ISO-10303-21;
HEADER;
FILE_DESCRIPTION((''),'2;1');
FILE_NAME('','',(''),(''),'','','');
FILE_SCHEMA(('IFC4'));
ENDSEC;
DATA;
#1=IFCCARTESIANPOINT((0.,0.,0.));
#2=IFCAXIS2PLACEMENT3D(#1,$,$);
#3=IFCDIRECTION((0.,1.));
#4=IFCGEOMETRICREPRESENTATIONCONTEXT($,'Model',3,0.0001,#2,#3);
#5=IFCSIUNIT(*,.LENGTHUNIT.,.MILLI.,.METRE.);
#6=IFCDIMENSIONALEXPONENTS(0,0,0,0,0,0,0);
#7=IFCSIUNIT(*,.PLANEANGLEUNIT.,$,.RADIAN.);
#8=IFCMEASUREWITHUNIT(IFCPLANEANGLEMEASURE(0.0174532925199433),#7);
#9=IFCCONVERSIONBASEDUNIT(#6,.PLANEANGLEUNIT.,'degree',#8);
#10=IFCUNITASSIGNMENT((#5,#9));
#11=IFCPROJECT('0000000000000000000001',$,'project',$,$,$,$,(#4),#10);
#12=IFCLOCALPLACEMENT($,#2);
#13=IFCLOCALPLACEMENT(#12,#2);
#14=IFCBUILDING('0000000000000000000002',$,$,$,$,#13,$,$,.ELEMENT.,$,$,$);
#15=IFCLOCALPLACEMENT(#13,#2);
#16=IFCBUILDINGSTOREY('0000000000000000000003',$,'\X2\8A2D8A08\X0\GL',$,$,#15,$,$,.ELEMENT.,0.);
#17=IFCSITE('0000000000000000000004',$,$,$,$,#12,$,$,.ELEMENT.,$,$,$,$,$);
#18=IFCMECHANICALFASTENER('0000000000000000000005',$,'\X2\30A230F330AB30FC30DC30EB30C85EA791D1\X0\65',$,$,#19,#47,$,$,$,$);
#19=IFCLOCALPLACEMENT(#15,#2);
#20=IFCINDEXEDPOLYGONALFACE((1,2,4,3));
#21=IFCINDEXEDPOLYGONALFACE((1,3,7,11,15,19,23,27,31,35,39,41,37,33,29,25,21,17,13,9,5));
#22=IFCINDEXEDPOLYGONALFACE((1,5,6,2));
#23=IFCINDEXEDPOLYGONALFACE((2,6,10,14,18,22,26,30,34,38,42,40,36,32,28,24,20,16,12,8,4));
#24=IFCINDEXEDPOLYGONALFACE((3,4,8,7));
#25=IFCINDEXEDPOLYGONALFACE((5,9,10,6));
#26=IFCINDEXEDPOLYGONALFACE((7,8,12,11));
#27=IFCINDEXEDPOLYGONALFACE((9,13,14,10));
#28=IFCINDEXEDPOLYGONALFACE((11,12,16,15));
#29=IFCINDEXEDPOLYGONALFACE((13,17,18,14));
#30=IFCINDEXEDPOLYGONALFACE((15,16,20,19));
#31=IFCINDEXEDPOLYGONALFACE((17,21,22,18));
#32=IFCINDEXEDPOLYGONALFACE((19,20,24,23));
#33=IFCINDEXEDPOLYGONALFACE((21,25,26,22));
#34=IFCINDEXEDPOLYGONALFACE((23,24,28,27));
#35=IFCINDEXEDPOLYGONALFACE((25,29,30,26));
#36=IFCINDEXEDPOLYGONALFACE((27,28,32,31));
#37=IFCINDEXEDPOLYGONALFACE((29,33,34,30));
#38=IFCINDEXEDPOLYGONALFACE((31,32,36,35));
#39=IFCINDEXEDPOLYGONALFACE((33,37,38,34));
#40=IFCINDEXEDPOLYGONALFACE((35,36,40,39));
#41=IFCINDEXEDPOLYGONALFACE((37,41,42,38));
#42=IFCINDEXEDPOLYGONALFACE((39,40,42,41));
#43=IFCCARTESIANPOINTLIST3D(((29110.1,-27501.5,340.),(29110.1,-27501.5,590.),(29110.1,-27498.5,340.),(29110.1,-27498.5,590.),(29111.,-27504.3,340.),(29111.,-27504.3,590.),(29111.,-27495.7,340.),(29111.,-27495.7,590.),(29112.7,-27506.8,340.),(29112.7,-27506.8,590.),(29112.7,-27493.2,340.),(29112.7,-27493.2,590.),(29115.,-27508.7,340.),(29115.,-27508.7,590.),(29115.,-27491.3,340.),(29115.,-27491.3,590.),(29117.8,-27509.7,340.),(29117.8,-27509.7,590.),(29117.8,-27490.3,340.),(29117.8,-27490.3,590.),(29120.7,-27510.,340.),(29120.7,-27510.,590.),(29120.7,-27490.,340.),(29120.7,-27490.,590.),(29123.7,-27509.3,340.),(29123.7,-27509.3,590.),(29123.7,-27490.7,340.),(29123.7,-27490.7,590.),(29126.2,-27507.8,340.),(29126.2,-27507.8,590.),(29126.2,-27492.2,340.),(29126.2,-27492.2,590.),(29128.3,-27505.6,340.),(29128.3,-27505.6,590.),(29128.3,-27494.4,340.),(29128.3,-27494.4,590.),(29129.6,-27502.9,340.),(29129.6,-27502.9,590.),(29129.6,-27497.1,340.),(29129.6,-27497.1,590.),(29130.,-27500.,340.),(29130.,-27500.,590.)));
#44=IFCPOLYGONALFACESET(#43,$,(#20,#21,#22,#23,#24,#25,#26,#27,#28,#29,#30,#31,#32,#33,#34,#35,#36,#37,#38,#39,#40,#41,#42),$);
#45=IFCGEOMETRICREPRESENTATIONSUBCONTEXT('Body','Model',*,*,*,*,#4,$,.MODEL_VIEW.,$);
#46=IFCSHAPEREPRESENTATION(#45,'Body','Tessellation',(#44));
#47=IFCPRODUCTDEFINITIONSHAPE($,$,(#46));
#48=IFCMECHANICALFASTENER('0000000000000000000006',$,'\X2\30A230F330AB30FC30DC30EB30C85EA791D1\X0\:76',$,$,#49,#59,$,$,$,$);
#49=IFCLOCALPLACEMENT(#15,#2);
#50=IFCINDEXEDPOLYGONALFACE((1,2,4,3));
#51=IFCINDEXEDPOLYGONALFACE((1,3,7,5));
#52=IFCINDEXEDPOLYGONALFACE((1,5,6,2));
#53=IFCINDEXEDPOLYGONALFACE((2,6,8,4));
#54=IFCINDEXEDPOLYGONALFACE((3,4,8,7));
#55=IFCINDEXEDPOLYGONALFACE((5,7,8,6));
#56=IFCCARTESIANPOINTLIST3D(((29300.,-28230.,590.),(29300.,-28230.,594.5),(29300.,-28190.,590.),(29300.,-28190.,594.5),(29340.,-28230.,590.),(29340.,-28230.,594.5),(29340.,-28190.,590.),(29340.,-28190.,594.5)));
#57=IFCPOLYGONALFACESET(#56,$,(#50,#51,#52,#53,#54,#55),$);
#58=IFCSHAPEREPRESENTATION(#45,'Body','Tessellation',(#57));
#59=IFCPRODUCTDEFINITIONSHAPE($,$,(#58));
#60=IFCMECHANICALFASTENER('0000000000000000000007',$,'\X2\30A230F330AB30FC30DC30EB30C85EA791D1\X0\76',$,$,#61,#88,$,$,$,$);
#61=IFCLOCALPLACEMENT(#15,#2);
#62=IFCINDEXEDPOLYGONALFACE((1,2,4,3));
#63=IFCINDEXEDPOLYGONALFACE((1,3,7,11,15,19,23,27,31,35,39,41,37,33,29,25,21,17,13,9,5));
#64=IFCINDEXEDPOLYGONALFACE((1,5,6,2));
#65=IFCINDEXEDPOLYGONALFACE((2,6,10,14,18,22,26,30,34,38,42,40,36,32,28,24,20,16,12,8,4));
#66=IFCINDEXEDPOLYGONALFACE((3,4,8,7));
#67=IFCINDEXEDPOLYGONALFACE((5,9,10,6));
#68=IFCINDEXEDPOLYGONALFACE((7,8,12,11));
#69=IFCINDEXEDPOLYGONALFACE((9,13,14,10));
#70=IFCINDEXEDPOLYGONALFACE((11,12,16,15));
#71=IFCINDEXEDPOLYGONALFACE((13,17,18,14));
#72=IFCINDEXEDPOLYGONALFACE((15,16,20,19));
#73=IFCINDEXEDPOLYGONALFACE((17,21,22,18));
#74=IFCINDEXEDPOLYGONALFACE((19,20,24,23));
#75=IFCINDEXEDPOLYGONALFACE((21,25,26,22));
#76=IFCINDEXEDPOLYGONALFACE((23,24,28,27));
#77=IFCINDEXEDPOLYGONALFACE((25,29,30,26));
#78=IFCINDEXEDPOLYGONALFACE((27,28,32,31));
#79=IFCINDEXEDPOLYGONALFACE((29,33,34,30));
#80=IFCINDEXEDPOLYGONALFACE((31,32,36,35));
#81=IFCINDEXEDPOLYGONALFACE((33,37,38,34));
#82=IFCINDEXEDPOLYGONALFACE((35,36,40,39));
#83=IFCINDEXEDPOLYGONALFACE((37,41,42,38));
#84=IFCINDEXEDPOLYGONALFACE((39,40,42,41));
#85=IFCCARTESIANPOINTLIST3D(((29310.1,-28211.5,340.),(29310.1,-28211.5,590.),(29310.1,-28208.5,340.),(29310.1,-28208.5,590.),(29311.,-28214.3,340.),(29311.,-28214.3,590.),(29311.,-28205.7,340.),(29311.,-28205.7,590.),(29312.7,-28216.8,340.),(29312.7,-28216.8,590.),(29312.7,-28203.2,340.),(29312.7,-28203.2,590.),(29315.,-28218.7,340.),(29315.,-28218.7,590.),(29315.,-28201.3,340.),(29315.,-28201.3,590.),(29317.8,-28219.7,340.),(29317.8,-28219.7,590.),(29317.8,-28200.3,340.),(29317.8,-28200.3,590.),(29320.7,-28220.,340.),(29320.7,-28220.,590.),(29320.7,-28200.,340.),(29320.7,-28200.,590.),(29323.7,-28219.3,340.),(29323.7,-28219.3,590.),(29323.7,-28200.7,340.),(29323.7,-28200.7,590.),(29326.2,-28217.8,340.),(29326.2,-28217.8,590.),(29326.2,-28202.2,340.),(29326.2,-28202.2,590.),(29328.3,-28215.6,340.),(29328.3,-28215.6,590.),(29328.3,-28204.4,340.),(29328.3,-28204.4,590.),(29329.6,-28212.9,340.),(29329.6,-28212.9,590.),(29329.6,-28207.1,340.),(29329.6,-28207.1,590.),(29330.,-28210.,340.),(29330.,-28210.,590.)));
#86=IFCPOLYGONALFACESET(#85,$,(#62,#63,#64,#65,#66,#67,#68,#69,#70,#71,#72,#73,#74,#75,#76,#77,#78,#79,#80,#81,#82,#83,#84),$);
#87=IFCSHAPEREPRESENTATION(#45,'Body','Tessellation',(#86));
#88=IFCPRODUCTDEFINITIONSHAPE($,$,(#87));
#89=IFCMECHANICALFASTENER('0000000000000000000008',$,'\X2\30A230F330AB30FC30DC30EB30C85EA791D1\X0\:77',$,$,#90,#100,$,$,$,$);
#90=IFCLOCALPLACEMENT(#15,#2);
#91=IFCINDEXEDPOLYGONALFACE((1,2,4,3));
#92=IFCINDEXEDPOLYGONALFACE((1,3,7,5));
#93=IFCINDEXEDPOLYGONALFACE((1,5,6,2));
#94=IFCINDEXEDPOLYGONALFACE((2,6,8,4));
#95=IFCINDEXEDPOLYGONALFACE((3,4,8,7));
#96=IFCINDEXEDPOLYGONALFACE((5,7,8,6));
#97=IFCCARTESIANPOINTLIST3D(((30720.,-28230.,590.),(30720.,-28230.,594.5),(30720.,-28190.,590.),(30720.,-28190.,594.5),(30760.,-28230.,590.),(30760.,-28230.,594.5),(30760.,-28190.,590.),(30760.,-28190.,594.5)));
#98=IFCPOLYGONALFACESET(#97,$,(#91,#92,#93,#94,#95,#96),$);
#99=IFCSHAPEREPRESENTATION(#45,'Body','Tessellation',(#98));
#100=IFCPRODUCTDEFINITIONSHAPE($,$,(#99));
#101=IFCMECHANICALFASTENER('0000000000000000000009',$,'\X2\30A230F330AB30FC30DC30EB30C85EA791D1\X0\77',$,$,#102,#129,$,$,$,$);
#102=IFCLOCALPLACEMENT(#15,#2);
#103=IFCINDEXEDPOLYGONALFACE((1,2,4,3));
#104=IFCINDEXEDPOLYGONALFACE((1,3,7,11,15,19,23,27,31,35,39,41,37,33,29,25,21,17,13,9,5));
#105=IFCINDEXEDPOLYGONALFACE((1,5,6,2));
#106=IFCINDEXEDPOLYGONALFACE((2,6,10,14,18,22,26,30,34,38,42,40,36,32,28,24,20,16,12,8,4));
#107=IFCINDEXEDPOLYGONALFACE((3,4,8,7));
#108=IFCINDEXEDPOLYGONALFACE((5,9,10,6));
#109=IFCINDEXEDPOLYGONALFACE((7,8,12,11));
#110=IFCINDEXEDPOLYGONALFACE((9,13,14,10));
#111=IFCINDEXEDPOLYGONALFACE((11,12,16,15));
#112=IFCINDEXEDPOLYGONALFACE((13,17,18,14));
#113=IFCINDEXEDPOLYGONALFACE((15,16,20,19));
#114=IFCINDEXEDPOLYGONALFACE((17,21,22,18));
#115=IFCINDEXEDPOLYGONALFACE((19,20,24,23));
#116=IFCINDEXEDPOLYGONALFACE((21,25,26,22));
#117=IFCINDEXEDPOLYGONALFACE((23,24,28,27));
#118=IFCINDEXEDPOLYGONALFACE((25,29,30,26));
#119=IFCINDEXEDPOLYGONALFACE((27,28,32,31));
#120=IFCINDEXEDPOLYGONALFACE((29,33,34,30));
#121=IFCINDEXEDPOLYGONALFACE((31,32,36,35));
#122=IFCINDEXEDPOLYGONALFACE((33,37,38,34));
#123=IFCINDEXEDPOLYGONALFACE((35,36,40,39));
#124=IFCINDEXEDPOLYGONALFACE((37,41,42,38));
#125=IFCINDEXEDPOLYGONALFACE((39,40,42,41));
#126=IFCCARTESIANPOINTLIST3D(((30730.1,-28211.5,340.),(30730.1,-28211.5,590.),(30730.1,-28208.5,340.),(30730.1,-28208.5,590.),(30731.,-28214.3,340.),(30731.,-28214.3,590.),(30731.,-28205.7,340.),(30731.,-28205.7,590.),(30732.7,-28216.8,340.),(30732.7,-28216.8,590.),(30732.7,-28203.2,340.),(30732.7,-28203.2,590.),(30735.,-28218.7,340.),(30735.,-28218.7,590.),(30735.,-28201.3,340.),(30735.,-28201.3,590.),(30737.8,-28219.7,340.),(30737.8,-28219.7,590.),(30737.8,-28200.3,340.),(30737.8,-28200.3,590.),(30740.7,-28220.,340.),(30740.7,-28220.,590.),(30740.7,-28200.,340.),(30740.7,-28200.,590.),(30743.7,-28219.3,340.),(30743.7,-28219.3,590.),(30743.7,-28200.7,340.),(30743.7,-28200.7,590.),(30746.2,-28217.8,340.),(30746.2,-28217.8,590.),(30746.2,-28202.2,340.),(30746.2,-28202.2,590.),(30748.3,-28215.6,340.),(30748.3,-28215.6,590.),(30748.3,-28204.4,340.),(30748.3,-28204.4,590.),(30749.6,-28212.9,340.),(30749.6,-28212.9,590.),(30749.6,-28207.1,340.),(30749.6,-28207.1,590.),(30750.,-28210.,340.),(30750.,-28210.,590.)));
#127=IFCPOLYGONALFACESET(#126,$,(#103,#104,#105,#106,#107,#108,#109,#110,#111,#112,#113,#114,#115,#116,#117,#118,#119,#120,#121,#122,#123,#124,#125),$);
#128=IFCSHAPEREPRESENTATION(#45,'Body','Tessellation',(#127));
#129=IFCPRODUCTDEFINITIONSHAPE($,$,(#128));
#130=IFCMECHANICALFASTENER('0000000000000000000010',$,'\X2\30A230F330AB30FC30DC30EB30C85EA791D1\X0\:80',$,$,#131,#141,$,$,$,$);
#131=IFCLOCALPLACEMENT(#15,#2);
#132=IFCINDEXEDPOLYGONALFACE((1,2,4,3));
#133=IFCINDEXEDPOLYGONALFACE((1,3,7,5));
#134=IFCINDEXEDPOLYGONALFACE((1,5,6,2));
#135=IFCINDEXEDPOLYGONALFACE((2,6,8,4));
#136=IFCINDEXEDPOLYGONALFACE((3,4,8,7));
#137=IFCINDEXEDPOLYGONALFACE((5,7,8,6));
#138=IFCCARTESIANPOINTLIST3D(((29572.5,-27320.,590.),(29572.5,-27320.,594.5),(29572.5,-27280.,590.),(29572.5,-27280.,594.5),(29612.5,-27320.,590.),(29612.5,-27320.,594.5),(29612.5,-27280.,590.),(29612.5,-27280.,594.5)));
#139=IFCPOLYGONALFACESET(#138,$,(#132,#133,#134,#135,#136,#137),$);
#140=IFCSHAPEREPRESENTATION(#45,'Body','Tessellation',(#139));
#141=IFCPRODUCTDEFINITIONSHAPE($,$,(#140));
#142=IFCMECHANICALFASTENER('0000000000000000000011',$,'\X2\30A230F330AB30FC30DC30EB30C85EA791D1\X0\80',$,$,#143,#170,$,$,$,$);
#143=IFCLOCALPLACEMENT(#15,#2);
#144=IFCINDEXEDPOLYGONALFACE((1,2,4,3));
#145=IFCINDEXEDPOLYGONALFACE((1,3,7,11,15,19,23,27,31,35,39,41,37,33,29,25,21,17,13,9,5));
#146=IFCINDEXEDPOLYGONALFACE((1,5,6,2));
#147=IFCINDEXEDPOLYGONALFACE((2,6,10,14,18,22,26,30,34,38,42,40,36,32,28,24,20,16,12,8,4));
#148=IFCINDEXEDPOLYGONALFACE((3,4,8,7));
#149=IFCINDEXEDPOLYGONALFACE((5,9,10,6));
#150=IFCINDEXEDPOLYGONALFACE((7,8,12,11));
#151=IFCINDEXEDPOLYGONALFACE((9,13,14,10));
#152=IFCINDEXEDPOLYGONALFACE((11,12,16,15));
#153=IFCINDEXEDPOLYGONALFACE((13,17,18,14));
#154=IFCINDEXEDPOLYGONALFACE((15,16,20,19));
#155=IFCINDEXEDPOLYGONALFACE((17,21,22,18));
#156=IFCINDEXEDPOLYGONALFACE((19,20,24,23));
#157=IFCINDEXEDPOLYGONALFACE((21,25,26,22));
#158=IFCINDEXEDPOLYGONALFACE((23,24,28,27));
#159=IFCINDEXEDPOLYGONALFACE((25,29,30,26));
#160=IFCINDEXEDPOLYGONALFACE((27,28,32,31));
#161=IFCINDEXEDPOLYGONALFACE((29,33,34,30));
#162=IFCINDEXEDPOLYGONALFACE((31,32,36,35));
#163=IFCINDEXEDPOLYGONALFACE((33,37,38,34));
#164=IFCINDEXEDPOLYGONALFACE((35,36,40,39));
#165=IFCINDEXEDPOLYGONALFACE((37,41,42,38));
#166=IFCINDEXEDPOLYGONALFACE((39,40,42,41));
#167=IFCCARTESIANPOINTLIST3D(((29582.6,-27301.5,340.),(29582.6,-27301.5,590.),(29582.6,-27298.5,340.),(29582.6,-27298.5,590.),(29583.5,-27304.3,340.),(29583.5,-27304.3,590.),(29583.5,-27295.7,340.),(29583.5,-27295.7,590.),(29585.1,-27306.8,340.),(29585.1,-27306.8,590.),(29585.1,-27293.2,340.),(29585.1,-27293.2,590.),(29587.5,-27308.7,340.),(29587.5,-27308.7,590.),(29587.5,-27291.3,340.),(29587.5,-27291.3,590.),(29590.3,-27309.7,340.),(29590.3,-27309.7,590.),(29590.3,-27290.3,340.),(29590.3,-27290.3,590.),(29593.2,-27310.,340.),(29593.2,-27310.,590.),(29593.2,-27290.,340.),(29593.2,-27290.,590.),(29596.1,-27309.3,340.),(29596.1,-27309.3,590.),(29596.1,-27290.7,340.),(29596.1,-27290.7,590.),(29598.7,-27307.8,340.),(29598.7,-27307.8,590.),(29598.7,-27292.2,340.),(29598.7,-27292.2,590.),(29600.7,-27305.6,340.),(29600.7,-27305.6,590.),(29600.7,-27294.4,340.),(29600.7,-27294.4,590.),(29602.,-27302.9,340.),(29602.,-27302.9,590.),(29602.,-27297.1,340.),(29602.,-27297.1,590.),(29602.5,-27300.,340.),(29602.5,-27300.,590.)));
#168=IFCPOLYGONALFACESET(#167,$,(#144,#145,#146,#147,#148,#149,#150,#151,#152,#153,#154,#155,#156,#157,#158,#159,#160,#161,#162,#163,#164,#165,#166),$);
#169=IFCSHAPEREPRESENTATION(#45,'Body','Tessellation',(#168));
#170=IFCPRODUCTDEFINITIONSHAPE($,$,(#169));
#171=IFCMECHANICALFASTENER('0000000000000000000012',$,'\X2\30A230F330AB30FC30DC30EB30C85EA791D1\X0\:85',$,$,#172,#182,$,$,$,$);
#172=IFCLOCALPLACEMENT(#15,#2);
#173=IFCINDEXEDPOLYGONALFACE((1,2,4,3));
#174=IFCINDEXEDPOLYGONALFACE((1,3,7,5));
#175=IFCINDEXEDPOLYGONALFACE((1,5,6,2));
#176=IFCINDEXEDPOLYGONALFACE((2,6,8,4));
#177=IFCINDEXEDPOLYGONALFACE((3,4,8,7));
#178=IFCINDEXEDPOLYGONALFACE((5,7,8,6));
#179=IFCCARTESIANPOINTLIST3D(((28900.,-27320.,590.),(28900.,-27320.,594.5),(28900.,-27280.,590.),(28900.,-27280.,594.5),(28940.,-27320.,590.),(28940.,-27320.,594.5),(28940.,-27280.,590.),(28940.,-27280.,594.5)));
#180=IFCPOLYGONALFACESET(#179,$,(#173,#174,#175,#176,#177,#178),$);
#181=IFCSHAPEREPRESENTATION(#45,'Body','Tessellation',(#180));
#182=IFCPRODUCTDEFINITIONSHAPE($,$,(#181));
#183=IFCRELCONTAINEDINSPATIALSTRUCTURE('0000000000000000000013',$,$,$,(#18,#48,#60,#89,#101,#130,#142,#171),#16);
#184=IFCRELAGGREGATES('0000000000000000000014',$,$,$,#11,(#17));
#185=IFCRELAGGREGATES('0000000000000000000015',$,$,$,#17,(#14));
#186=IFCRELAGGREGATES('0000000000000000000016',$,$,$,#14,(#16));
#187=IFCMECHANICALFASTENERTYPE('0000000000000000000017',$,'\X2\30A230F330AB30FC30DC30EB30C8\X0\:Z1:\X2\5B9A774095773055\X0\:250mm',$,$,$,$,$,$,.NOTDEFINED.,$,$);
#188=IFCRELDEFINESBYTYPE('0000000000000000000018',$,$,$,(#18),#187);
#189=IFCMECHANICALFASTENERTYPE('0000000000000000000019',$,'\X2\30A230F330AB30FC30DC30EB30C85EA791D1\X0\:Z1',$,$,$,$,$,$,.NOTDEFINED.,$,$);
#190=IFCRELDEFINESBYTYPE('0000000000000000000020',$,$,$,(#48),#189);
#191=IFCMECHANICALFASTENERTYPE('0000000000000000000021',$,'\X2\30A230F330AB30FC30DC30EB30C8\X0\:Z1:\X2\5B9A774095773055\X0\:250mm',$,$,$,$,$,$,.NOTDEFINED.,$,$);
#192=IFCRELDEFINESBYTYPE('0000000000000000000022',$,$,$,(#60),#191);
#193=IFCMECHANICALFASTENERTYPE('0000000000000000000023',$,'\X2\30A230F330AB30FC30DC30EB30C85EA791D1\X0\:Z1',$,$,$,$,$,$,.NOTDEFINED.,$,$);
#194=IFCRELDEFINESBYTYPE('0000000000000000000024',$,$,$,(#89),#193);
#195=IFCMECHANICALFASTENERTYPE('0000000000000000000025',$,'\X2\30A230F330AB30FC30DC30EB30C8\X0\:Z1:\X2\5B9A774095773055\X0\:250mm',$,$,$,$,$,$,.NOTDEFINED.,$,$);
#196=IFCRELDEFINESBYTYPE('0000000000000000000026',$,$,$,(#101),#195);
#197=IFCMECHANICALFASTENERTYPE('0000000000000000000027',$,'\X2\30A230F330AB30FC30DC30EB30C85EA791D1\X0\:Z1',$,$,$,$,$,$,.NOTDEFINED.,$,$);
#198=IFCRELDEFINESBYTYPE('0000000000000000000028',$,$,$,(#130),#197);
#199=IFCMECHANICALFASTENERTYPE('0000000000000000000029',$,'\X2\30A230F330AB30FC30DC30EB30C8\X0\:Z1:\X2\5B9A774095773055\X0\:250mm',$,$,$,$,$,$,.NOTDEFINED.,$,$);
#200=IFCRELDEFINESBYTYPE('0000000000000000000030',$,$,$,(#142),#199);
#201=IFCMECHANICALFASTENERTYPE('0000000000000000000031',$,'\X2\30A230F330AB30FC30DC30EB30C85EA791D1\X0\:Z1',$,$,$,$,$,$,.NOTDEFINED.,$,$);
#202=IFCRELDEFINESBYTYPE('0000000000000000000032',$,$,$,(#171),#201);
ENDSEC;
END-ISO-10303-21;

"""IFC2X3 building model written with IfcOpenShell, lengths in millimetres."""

from ifc_helpers import new_model, entity, si_unit, converted_unit, direction, frame, origin, origin_with_axes, origin_2d, place, context, subcontext, project, spatial, rectangle, circle, extrude, type_object, element, save


model = new_model("IFC2X3")

# Units and contexts
model_context = context("Model", 3, precision=0.0001, world=origin(), true_north=direction((0.0, 1.0)))
body_context = subcontext(model_context, "Body", "Model", "MODEL_VIEW")
ifc_project = project(units=[si_unit("LENGTHUNIT", "METRE", prefix="MILLI"), converted_unit("PLANEANGLEUNIT", "degree", entity("IfcPlaneAngleMeasure", 0.0174532925199433), si_unit("PLANEANGLEUNIT", "RADIAN"), dimensions=[0, 0, 0, 0, 0, 0, 0])], contexts=[model_context])

# Site, building, storey
site_placement = place(None, origin())
site = spatial("IfcSite", under=ifc_project, at=site_placement, CompositionType="ELEMENT")
building_placement = place(site_placement, origin())
building = spatial("IfcBuilding", under=site, at=building_placement, CompositionType="ELEMENT")
storey_placement = place(building_placement, origin())
storey = spatial("IfcBuildingStorey", under=building, at=storey_placement, Name="設計GL", CompositionType="ELEMENT", Elevation=0.0)

# Mechanical fasteners
mechanical_fastener_type_1 = type_object("IfcMechanicalFastenerType", Name="アンカーボルト:Z1:定着長さ:250mm")
mechanical_fastener_1_placement = place(storey_placement, frame((29120.0, -27500.0, 340.0)))
element("IfcMechanicalFastener", 1, at=mechanical_fastener_1_placement, inside=storey, type_object=mechanical_fastener_type_1, Name="アンカーボルト座金65", context=body_context, shape_type="SweptSolid", body=[
    extrude(circle(Radius=10.0, at=origin_2d()), origin_with_axes(), (0.0, 0.0, 1.0), 250.0),
])
mechanical_fastener_type_2 = type_object("IfcMechanicalFastenerType", Name="アンカーボルト座金:Z1")
mechanical_fastener_2_placement = place(storey_placement, frame((29320.0, -28210.0, 590.0)))
element("IfcMechanicalFastener", 2, at=mechanical_fastener_2_placement, inside=storey, type_object=mechanical_fastener_type_2, Name="アンカーボルト座金:76", context=body_context, shape_type="SweptSolid", body=[
    extrude(rectangle(XDim=40.0, YDim=40.0, at=origin_2d()), origin_with_axes(), (0.0, 0.0, 1.0), 4.5),
])
mechanical_fastener_type_3 = type_object("IfcMechanicalFastenerType", Name="アンカーボルト:Z1:定着長さ:250mm")
mechanical_fastener_3_placement = place(storey_placement, frame((29320.0, -28210.0, 340.0)))
element("IfcMechanicalFastener", 3, at=mechanical_fastener_3_placement, inside=storey, type_object=mechanical_fastener_type_3, Name="アンカーボルト座金76", context=body_context, shape_type="SweptSolid", body=[
    extrude(circle(Radius=10.0, at=origin_2d()), origin_with_axes(), (0.0, 0.0, 1.0), 250.0),
])
mechanical_fastener_type_4 = type_object("IfcMechanicalFastenerType", Name="アンカーボルト座金:Z1")
mechanical_fastener_4_placement = place(storey_placement, frame((30740.0, -28210.0, 590.0)))
element("IfcMechanicalFastener", 4, at=mechanical_fastener_4_placement, inside=storey, type_object=mechanical_fastener_type_4, Name="アンカーボルト座金:77", context=body_context, shape_type="SweptSolid", body=[
    extrude(rectangle(XDim=40.0, YDim=40.0, at=origin_2d()), origin_with_axes(), (0.0, 0.0, 1.0), 4.5),
])
mechanical_fastener_type_5 = type_object("IfcMechanicalFastenerType", Name="アンカーボルト:Z1:定着長さ:250mm")
mechanical_fastener_5_placement = place(storey_placement, frame((30740.0, -28210.0, 340.0)))
element("IfcMechanicalFastener", 5, at=mechanical_fastener_5_placement, inside=storey, type_object=mechanical_fastener_type_5, Name="アンカーボルト座金77", context=body_context, shape_type="SweptSolid", body=[
    extrude(circle(Radius=10.0, at=origin_2d()), origin_with_axes(), (0.0, 0.0, 1.0), 250.0),
])
mechanical_fastener_type_6 = type_object("IfcMechanicalFastenerType", Name="アンカーボルト座金:Z1")
mechanical_fastener_6_placement = place(storey_placement, frame((29592.5, -27300.0, 590.0)))
element("IfcMechanicalFastener", 6, at=mechanical_fastener_6_placement, inside=storey, type_object=mechanical_fastener_type_6, Name="アンカーボルト座金:80", context=body_context, shape_type="SweptSolid", body=[
    extrude(rectangle(XDim=40.0, YDim=40.0, at=origin_2d()), origin_with_axes(), (0.0, 0.0, 1.0), 4.5),
])
mechanical_fastener_type_7 = type_object("IfcMechanicalFastenerType", Name="アンカーボルト:Z1:定着長さ:250mm")
mechanical_fastener_7_placement = place(storey_placement, frame((29592.5, -27300.0, 340.0)))
element("IfcMechanicalFastener", 7, at=mechanical_fastener_7_placement, inside=storey, type_object=mechanical_fastener_type_7, Name="アンカーボルト座金80", context=body_context, shape_type="SweptSolid", body=[
    extrude(circle(Radius=10.0, at=origin_2d()), origin_with_axes(), (0.0, 0.0, 1.0), 250.0),
])
mechanical_fastener_type_8 = type_object("IfcMechanicalFastenerType", Name="アンカーボルト座金:Z1")
mechanical_fastener_8_placement = place(storey_placement, frame((28920.0, -27300.0, 590.0)))
element("IfcMechanicalFastener", 8, at=mechanical_fastener_8_placement, inside=storey, type_object=mechanical_fastener_type_8, Name="アンカーボルト座金:85", context=body_context, shape_type="SweptSolid", body=[
    extrude(rectangle(XDim=40.0, YDim=40.0, at=origin_2d()), origin_with_axes(), (0.0, 0.0, 1.0), 4.5),
])

save(model, "model.ifc")
